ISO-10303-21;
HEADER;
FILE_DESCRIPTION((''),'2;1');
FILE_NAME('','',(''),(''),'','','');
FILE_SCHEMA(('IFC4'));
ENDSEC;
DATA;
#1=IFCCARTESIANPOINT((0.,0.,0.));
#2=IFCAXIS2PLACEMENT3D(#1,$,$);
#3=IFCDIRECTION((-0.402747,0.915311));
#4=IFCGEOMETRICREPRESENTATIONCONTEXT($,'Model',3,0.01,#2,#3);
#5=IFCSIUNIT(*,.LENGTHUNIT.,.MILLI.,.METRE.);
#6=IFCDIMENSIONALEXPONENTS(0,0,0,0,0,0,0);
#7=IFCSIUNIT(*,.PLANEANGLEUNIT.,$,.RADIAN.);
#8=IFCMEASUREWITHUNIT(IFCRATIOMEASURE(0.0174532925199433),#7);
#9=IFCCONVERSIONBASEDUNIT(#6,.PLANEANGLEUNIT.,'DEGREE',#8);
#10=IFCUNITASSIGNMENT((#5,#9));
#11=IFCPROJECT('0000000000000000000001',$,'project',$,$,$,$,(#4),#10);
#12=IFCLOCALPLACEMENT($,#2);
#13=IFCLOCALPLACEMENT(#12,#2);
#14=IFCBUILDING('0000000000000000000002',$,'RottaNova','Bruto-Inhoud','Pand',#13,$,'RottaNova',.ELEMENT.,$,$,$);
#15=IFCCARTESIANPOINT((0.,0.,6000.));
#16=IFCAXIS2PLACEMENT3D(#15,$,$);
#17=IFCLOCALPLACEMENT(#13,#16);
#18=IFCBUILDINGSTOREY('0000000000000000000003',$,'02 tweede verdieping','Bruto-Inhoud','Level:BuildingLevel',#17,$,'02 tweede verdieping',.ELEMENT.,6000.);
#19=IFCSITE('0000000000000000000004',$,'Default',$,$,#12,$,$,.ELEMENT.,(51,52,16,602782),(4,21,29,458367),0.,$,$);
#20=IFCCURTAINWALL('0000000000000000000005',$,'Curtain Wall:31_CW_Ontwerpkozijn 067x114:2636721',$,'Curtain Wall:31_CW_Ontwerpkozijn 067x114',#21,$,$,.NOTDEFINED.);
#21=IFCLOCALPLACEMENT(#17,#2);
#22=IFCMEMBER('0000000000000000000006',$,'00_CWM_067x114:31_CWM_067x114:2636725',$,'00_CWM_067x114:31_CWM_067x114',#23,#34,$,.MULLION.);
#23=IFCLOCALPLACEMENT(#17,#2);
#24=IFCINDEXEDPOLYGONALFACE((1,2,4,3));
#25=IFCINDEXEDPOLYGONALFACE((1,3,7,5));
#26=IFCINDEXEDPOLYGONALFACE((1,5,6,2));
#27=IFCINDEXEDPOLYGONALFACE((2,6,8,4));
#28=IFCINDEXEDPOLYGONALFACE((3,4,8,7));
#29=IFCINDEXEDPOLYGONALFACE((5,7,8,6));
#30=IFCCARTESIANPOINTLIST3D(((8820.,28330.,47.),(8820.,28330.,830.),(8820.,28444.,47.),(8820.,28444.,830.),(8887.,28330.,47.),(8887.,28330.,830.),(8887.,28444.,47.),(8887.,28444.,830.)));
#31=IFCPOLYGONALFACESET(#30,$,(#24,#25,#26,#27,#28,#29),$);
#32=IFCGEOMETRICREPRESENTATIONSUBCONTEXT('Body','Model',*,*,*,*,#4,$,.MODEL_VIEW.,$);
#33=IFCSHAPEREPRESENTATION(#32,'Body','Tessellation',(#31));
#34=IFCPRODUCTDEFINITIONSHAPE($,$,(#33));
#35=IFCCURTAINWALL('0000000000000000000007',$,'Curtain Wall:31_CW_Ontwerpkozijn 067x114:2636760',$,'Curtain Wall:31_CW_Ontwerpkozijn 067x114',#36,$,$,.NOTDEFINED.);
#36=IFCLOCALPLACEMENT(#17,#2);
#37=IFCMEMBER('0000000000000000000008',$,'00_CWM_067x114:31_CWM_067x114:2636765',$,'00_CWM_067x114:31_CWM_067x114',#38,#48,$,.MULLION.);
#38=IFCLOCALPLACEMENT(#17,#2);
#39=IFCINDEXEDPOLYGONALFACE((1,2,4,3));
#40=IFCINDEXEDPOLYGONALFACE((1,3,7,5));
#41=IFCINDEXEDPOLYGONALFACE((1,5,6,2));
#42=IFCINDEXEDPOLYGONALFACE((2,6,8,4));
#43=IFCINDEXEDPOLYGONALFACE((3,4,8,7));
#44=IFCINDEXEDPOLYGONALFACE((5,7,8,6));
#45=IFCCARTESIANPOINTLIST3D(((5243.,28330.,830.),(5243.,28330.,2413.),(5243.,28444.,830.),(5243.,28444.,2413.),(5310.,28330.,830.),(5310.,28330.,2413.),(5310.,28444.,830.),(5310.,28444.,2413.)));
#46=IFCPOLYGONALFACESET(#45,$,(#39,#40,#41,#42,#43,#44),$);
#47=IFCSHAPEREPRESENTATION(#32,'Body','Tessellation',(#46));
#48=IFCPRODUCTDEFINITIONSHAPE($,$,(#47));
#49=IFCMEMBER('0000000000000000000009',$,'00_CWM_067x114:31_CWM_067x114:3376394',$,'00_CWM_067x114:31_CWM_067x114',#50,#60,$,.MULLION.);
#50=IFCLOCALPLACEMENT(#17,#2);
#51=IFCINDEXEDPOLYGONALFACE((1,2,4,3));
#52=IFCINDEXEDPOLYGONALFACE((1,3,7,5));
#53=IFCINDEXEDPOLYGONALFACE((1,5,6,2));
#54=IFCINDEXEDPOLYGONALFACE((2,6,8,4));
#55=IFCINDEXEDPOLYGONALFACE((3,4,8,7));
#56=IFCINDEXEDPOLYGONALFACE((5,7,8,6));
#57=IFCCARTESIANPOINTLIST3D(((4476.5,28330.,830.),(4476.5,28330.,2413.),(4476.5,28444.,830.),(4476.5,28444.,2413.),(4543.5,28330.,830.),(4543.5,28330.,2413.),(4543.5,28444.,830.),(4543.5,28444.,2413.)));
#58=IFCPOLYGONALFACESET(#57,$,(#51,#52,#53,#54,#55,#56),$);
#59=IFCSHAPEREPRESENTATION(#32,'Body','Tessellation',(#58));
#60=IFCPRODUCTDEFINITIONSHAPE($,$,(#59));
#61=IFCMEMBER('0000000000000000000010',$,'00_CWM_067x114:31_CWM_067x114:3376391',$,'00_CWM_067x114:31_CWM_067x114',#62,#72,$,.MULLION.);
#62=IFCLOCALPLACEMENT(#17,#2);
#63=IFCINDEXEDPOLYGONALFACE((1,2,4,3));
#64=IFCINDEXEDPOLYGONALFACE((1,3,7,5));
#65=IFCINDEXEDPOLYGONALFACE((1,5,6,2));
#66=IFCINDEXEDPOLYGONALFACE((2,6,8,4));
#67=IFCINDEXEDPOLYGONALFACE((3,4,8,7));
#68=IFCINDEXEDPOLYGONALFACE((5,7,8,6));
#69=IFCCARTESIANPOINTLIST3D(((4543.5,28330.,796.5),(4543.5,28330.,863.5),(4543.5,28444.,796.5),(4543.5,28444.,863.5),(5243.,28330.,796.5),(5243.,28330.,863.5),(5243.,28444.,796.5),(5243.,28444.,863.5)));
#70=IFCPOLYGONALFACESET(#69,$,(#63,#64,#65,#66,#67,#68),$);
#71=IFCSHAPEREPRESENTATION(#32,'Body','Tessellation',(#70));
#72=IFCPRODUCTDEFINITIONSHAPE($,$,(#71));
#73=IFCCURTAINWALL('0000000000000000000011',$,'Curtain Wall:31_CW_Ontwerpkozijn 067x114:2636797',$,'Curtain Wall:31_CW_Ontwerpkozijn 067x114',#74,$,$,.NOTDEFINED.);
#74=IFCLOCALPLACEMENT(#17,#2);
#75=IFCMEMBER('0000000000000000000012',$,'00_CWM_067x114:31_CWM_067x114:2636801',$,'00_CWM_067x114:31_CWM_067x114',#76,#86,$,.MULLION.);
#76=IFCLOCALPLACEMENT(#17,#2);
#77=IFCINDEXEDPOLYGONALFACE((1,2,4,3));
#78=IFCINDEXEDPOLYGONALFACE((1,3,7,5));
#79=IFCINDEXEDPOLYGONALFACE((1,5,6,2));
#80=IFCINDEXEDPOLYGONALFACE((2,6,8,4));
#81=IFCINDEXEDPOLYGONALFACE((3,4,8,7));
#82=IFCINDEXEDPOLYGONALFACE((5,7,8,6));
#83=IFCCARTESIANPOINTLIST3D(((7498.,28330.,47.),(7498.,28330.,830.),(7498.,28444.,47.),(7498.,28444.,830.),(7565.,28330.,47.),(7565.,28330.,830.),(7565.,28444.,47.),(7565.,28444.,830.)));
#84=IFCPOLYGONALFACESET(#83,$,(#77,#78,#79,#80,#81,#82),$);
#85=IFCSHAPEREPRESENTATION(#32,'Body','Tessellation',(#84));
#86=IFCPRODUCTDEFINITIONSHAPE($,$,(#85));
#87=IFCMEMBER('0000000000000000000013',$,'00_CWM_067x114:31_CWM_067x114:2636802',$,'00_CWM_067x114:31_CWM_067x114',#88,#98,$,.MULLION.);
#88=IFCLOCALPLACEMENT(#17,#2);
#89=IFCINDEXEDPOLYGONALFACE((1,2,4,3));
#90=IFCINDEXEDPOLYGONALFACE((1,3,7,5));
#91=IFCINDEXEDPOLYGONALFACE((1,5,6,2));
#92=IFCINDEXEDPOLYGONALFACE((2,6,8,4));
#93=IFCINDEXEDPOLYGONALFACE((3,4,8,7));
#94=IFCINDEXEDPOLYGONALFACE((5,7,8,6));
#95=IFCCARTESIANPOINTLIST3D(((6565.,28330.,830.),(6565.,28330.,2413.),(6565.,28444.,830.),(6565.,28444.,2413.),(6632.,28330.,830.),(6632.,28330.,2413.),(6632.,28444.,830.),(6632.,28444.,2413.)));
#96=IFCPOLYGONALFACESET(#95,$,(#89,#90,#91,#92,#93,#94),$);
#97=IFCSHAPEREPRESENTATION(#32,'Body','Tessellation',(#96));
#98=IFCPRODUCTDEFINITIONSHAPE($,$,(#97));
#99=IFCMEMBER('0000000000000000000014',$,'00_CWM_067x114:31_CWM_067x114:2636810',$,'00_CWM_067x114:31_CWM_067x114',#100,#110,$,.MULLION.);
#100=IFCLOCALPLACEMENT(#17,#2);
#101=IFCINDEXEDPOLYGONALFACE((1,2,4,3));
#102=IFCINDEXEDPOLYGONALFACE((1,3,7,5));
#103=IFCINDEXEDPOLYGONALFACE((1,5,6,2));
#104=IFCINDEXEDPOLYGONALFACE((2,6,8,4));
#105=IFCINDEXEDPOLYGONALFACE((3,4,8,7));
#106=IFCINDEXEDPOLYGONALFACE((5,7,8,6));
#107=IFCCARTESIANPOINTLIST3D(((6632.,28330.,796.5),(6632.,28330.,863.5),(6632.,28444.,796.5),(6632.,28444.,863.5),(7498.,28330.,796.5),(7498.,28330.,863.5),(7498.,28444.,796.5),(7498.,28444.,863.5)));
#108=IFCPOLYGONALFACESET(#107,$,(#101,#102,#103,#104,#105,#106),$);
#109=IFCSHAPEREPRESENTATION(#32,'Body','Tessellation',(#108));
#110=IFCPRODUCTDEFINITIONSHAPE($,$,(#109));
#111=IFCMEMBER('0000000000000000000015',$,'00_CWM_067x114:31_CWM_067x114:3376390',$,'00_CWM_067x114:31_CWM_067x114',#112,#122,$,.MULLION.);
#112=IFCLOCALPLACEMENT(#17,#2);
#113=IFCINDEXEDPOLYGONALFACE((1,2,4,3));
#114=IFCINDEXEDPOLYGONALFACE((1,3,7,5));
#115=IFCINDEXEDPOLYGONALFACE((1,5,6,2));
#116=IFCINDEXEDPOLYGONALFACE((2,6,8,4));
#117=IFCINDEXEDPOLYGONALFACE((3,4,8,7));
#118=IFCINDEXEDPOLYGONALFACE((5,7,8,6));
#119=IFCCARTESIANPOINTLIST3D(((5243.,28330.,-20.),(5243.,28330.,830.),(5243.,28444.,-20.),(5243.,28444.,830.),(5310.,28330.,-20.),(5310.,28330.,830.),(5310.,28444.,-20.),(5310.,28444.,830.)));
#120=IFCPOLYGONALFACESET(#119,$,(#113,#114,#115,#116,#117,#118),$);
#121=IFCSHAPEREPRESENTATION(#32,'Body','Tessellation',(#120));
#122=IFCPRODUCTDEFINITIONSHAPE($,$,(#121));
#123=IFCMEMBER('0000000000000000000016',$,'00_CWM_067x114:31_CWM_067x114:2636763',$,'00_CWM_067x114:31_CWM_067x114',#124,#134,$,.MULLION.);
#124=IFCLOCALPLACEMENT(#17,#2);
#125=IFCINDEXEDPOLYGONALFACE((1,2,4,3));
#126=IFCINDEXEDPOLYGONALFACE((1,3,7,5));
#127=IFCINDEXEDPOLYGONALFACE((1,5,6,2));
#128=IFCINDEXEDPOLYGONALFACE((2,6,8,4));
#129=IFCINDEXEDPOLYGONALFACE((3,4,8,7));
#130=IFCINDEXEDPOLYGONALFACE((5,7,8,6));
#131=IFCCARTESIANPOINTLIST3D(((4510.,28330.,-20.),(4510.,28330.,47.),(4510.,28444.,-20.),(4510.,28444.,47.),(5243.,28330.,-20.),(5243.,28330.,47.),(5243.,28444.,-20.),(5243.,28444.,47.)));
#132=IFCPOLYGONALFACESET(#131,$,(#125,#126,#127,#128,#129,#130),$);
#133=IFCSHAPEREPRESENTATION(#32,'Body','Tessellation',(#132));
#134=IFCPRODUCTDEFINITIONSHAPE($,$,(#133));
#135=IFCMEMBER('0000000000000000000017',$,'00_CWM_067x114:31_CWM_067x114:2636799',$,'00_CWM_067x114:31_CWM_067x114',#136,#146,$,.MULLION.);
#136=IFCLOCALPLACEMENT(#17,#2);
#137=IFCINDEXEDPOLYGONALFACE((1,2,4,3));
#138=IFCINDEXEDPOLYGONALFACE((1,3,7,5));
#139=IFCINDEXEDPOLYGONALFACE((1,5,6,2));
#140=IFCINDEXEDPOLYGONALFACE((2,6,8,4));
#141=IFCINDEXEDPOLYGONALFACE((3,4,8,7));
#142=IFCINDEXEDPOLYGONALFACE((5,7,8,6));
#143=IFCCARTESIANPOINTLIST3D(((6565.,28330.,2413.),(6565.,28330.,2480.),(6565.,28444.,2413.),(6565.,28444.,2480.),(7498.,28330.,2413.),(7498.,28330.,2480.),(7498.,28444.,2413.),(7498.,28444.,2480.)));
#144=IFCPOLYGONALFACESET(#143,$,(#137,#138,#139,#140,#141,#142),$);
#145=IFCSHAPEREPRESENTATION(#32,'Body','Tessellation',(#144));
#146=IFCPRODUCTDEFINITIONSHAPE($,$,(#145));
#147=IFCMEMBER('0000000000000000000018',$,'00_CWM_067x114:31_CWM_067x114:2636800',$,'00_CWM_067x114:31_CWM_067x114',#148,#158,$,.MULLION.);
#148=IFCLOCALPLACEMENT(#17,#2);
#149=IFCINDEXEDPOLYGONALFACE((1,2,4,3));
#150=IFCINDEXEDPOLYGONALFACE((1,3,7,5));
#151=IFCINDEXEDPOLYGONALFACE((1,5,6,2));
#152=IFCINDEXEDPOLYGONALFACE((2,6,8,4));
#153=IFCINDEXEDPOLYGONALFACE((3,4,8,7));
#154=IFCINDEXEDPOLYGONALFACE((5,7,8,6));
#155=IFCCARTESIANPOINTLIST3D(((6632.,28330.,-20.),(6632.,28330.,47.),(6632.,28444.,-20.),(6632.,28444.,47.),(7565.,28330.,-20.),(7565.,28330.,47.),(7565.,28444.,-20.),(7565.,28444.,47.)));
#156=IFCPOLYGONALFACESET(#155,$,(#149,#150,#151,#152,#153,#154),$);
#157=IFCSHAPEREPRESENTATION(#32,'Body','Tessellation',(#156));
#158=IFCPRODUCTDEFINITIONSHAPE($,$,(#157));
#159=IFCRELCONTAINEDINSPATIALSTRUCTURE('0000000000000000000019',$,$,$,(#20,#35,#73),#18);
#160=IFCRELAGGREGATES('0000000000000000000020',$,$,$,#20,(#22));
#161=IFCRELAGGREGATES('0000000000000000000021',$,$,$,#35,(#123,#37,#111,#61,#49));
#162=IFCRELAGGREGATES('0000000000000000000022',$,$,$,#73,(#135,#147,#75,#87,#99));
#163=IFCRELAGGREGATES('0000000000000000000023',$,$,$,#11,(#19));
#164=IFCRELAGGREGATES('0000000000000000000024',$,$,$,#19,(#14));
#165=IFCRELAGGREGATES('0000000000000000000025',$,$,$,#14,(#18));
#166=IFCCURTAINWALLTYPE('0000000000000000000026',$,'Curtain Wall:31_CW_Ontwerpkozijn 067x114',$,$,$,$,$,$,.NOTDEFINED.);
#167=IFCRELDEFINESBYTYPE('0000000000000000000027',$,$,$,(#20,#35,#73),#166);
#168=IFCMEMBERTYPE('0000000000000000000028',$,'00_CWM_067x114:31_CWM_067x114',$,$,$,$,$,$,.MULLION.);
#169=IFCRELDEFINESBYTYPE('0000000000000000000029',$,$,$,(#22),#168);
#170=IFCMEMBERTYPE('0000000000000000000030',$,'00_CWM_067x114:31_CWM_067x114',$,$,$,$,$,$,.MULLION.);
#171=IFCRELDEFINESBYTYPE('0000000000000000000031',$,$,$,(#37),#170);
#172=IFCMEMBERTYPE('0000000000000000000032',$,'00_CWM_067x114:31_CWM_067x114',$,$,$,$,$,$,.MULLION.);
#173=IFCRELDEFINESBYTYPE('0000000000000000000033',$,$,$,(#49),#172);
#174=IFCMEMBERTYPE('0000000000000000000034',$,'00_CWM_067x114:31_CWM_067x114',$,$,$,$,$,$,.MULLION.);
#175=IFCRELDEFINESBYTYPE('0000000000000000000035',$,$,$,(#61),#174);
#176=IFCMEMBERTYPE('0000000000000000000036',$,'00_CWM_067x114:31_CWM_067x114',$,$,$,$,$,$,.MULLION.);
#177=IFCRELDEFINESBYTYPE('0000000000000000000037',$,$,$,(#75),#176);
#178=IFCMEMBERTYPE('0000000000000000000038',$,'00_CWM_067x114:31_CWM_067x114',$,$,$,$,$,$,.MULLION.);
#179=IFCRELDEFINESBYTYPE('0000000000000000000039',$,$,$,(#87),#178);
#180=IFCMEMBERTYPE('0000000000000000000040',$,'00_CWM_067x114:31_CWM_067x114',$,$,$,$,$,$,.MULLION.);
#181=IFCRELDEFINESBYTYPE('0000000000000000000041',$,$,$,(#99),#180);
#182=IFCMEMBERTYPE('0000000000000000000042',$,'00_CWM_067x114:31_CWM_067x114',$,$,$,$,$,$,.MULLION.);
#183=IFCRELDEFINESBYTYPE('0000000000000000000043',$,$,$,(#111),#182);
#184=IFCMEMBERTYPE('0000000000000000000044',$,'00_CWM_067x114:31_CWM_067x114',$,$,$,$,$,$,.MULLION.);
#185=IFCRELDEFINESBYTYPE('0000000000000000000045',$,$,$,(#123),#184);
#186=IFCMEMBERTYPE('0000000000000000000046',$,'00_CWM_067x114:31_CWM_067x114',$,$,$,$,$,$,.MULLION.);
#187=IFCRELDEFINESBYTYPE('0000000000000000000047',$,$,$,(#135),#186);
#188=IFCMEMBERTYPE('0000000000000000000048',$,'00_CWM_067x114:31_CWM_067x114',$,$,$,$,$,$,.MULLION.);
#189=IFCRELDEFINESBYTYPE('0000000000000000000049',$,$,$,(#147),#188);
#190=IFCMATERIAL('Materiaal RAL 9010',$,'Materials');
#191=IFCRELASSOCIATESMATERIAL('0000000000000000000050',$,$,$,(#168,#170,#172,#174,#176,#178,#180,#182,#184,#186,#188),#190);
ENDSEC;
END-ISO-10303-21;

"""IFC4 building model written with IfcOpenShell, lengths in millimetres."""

from ifc_helpers import new_model, entity, si_unit, converted_unit, direction, frame, frame_2d, origin, origin_2d_with_axis, place, context, subcontext, project, spatial, rectangle, extrude, source, transform, mapped, material, material_profile, profile_set, type_object, type_shapes, element, aggregate, save


model = new_model("IFC4")

# Units and contexts
model_context = context("Model", 3, precision=0.01, world=origin(), true_north=direction((-0.402747, 0.915311)))
body_context = subcontext(model_context, "Body", "Model", "MODEL_VIEW")
ifc_project = project(units=[si_unit("LENGTHUNIT", "METRE", prefix="MILLI"), converted_unit("PLANEANGLEUNIT", "DEGREE", entity("IfcRatioMeasure", 0.0174532925199433), si_unit("PLANEANGLEUNIT", "RADIAN"), dimensions=[0, 0, 0, 0, 0, 0, 0])], contexts=[model_context])

# Site, building, storey
site_placement = place(None, origin())
site = spatial("IfcSite", under=ifc_project, at=site_placement, Name="Default", CompositionType="ELEMENT", RefLatitude=(51, 52, 16, 602782), RefLongitude=(4, 21, 29, 458367), RefElevation=0.0)
building_placement = place(site_placement, origin())
building = spatial("IfcBuilding", under=site, at=building_placement, Name="RottaNova", Description="Bruto-Inhoud", ObjectType="Pand", LongName="RottaNova", CompositionType="ELEMENT")
storey_placement = place(building_placement, frame((0.0, 0.0, 6000.0)))
storey = spatial("IfcBuildingStorey", under=building, at=storey_placement, Name="02 tweede verdieping", Description="Bruto-Inhoud", ObjectType="Level:BuildingLevel", LongName="02 tweede verdieping", CompositionType="ELEMENT", Elevation=6000.0)

# Curtain wall, member
curtain_wall_type = type_object("IfcCurtainWallType", Name="Curtain Wall:31_CW_Ontwerpkozijn 067x114", PredefinedType="NOTDEFINED")
curtain_wall_1_placement = place(storey_placement, frame((0.0, 0.0, -6000.0)))
curtain_wall_1 = element("IfcCurtainWall", 1, at=curtain_wall_1_placement, inside=storey, type_object=curtain_wall_type, Name="Curtain Wall:31_CW_Ontwerpkozijn 067x114:2636721", ObjectType="Curtain Wall:31_CW_Ontwerpkozijn 067x114", PredefinedType="NOTDEFINED")
ifc_material_1 = material(Name="Materiaal RAL 9010", Category="Materials")
ifc_material_profile = material_profile(ifc_material_1, rectangle(XDim=114.0, YDim=67.0, at=origin_2d_with_axis()), Name="31_CWM_067x114")
ifc_profile_set = profile_set([ifc_material_profile], Name="31_CWM_067x114")
member_type_1 = type_object("IfcMemberType", Name="00_CWM_067x114:31_CWM_067x114", PredefinedType="MULLION", material=ifc_profile_set)
shared_shape_1 = source(origin(), body_context, "Body", "SweptSolid", [
    extrude(rectangle(XDim=114.0, YDim=67.0, at=origin_2d_with_axis()), frame((-33.5, 57.0, -783.0), z_axis=(0.0, 0.0, 1.0), x_axis=(0.0, -1.0, 0.0)), (0.0, 0.0, 1.0), 783.0),
])
type_shapes(member_type_1, [shared_shape_1])
member_1_placement = place(curtain_wall_1_placement, frame((8820.0, 28330.0, 6047.0), z_axis=(0.0, 0.0, -1.0), x_axis=(-1.0, 0.0, 0.0)))
member_1 = element("IfcMember", 2, at=member_1_placement, type_object=member_type_1, Name="00_CWM_067x114:31_CWM_067x114:2636725", ObjectType="00_CWM_067x114:31_CWM_067x114", PredefinedType="MULLION", context=body_context, shape_type="MappedRepresentation", body=[
    mapped(shared_shape_1, transform((0.0, 0.0, 0.0), scale=1.0)),
])
aggregate(curtain_wall_1, [member_1])

# Curtain walls, members
curtain_wall_2_placement = place(storey_placement, frame((0.0, 0.0, -6000.0)))
curtain_wall_2 = element("IfcCurtainWall", 3, at=curtain_wall_2_placement, inside=storey, type_object=curtain_wall_type, Name="Curtain Wall:31_CW_Ontwerpkozijn 067x114:2636760", ObjectType="Curtain Wall:31_CW_Ontwerpkozijn 067x114", PredefinedType="NOTDEFINED")
member_type_2 = type_object("IfcMemberType", Name="00_CWM_067x114:31_CWM_067x114", PredefinedType="MULLION", material=ifc_profile_set)
shared_shape_2 = source(origin(), body_context, "Body", "SweptSolid", [
    extrude(rectangle(XDim=114.0, YDim=67.0, at=origin_2d_with_axis()), frame((-33.5, 57.0, -1583.0), z_axis=(0.0, 0.0, 1.0), x_axis=(0.0, -1.0, 0.0)), (0.0, 0.0, 1.0), 1583.0),
])
type_shapes(member_type_2, [shared_shape_2])
member_2_placement = place(curtain_wall_2_placement, frame((5310.0, 28330.0, 8413.0)))
member_2 = element("IfcMember", 4, at=member_2_placement, type_object=member_type_2, Name="00_CWM_067x114:31_CWM_067x114:2636765", ObjectType="00_CWM_067x114:31_CWM_067x114", PredefinedType="MULLION", context=body_context, shape_type="MappedRepresentation", body=[
    mapped(shared_shape_2, transform((0.0, 0.0, 0.0), scale=1.0)),
])
member_type_3 = type_object("IfcMemberType", Name="00_CWM_067x114:31_CWM_067x114", PredefinedType="MULLION", material=ifc_profile_set)
shared_shape_3 = source(origin(), body_context, "Body", "SweptSolid", [
    extrude(rectangle(XDim=114.0, YDim=67.0, at=origin_2d_with_axis()), frame((0.0, 57.0, -1583.0), z_axis=(0.0, 0.0, 1.0), x_axis=(0.0, -1.0, 0.0)), (0.0, 0.0, 1.0), 1583.0),
])
type_shapes(member_type_3, [shared_shape_3])
member_3_placement = place(curtain_wall_2_placement, frame((4510.0, 28330.0, 6830.0), z_axis=(0.0, 0.0, -1.0), x_axis=(-1.0, 0.0, 0.0)))
member_3 = element("IfcMember", 5, at=member_3_placement, type_object=member_type_3, Name="00_CWM_067x114:31_CWM_067x114:3376394", ObjectType="00_CWM_067x114:31_CWM_067x114", PredefinedType="MULLION", context=body_context, shape_type="MappedRepresentation", body=[
    mapped(shared_shape_3, transform((0.0, 0.0, 0.0), scale=1.0)),
])
member_type_4 = type_object("IfcMemberType", Name="00_CWM_067x114:31_CWM_067x114", PredefinedType="MULLION", material=ifc_profile_set)
shared_shape_4 = source(origin(), body_context, "Body", "SweptSolid", [
    extrude(rectangle(XDim=114.0, YDim=67.0, at=origin_2d_with_axis()), frame((0.0, 57.0, -699.5), z_axis=(0.0, 0.0, 1.0), x_axis=(0.0, -1.0, 0.0)), (0.0, 0.0, 1.0), 699.5),
])
type_shapes(member_type_4, [shared_shape_4])
member_4_placement = place(curtain_wall_2_placement, frame((4543.5, 28330.0, 6830.0), z_axis=(-1.0, 0.0, 0.0), x_axis=(0.0, 0.0, 1.0)))
member_4 = element("IfcMember", 6, at=member_4_placement, type_object=member_type_4, Name="00_CWM_067x114:31_CWM_067x114:3376391", ObjectType="00_CWM_067x114:31_CWM_067x114", PredefinedType="MULLION", context=body_context, shape_type="MappedRepresentation", body=[
    mapped(shared_shape_4, transform((0.0, 0.0, 0.0), scale=1.0)),
])
curtain_wall_3_placement = place(storey_placement, frame((0.0, 0.0, -6000.0)))
curtain_wall_3 = element("IfcCurtainWall", 7, at=curtain_wall_3_placement, inside=storey, type_object=curtain_wall_type, Name="Curtain Wall:31_CW_Ontwerpkozijn 067x114:2636797", ObjectType="Curtain Wall:31_CW_Ontwerpkozijn 067x114", PredefinedType="NOTDEFINED")
member_type_5 = type_object("IfcMemberType", Name="00_CWM_067x114:31_CWM_067x114", PredefinedType="MULLION", material=ifc_profile_set)
shared_shape_5 = source(origin(), body_context, "Body", "SweptSolid", [
    extrude(rectangle(XDim=114.0, YDim=67.0, at=frame_2d((0.0, 0.0), x_axis=(1.0, 0.0))), frame((-33.5, -57.0, -783.0), z_axis=(0.0, 0.0, 1.0), x_axis=(0.0, -1.0, 0.0)), (0.0, 0.0, 1.0), 783.0),
])
type_shapes(member_type_5, [shared_shape_5])
member_5_placement = place(curtain_wall_3_placement, frame((7565.0, 28330.0, 6047.0), z_axis=(0.0, 0.0, -1.0), x_axis=(1.0, 0.0, 0.0)))
member_5 = element("IfcMember", 8, at=member_5_placement, type_object=member_type_5, Name="00_CWM_067x114:31_CWM_067x114:2636801", ObjectType="00_CWM_067x114:31_CWM_067x114", PredefinedType="MULLION", context=body_context, shape_type="MappedRepresentation", body=[
    mapped(shared_shape_5, transform((0.0, 0.0, 0.0), scale=1.0)),
])
member_type_6 = type_object("IfcMemberType", Name="00_CWM_067x114:31_CWM_067x114", PredefinedType="MULLION", material=ifc_profile_set)
shared_shape_6 = source(origin(), body_context, "Body", "SweptSolid", [
    extrude(rectangle(XDim=114.0, YDim=67.0, at=frame_2d((0.0, 0.0), x_axis=(1.0, 0.0))), frame((-33.5, -57.0, -1583.0), z_axis=(0.0, 0.0, 1.0), x_axis=(0.0, -1.0, 0.0)), (0.0, 0.0, 1.0), 1583.0),
])
type_shapes(member_type_6, [shared_shape_6])
member_6_placement = place(curtain_wall_3_placement, frame((6565.0, 28330.0, 8413.0), z_axis=(0.0, 0.0, 1.0), x_axis=(-1.0, 0.0, 0.0)))
member_6 = element("IfcMember", 9, at=member_6_placement, type_object=member_type_6, Name="00_CWM_067x114:31_CWM_067x114:2636802", ObjectType="00_CWM_067x114:31_CWM_067x114", PredefinedType="MULLION", context=body_context, shape_type="MappedRepresentation", body=[
    mapped(shared_shape_6, transform((0.0, 0.0, 0.0), scale=1.0)),
])
member_type_7 = type_object("IfcMemberType", Name="00_CWM_067x114:31_CWM_067x114", PredefinedType="MULLION", material=ifc_profile_set)
shared_shape_7 = source(origin(), body_context, "Body", "SweptSolid", [
    extrude(rectangle(XDim=114.0, YDim=67.0, at=origin_2d_with_axis()), frame((0.0, -57.0, -866.0), z_axis=(0.0, 0.0, 1.0), x_axis=(0.0, -1.0, 0.0)), (0.0, 0.0, 1.0), 866.0),
])
type_shapes(member_type_7, [shared_shape_7])
member_7_placement = place(curtain_wall_3_placement, frame((7498.0, 28330.0, 6830.0), z_axis=(1.0, 0.0, 0.0), x_axis=(0.0, 0.0, 1.0)))
member_7 = element("IfcMember", 10, at=member_7_placement, type_object=member_type_7, Name="00_CWM_067x114:31_CWM_067x114:2636810", ObjectType="00_CWM_067x114:31_CWM_067x114", PredefinedType="MULLION", context=body_context, shape_type="MappedRepresentation", body=[
    mapped(shared_shape_7, transform((0.0, 0.0, 0.0), scale=1.0)),
])

# Members
member_type_8 = type_object("IfcMemberType", Name="00_CWM_067x114:31_CWM_067x114", PredefinedType="MULLION", material=ifc_profile_set)
shared_shape_8 = source(origin(), body_context, "Body", "SweptSolid", [
    extrude(rectangle(XDim=114.0, YDim=67.0, at=origin_2d_with_axis()), frame((-33.5, 57.0, -850.0), z_axis=(0.0, 0.0, 1.0), x_axis=(0.0, -1.0, 0.0)), (0.0, 0.0, 1.0), 850.0),
])
type_shapes(member_type_8, [shared_shape_8])
member_8_placement = place(curtain_wall_2_placement, frame((5310.0, 28330.0, 6830.0)))
member_8 = element("IfcMember", 11, at=member_8_placement, type_object=member_type_8, Name="00_CWM_067x114:31_CWM_067x114:3376390", ObjectType="00_CWM_067x114:31_CWM_067x114", PredefinedType="MULLION", context=body_context, shape_type="MappedRepresentation", body=[
    mapped(shared_shape_8, transform((0.0, 0.0, 0.0), scale=1.0)),
])
member_type_9 = type_object("IfcMemberType", Name="00_CWM_067x114:31_CWM_067x114", PredefinedType="MULLION", material=ifc_profile_set)
shared_shape_9 = source(origin(), body_context, "Body", "SweptSolid", [
    extrude(rectangle(XDim=114.0, YDim=67.0, at=origin_2d_with_axis()), frame((-33.5, 57.0, -733.0), z_axis=(0.0, 0.0, 1.0), x_axis=(0.0, -1.0, 0.0)), (0.0, 0.0, 1.0), 733.0),
])
type_shapes(member_type_9, [shared_shape_9])
member_9_placement = place(curtain_wall_2_placement, frame((5243.0, 28330.0, 5980.0), z_axis=(1.0, 0.0, 0.0), x_axis=(0.0, 0.0, -1.0)))
member_9 = element("IfcMember", 12, at=member_9_placement, type_object=member_type_9, Name="00_CWM_067x114:31_CWM_067x114:2636763", ObjectType="00_CWM_067x114:31_CWM_067x114", PredefinedType="MULLION", context=body_context, shape_type="MappedRepresentation", body=[
    mapped(shared_shape_9, transform((0.0, 0.0, 0.0), scale=1.0)),
])
member_type_10 = type_object("IfcMemberType", Name="00_CWM_067x114:31_CWM_067x114", PredefinedType="MULLION", material=ifc_profile_set)
shared_shape_10 = source(origin(), body_context, "Body", "SweptSolid", [
    extrude(rectangle(XDim=114.0, YDim=67.0, at=frame_2d((0.0, 0.0), x_axis=(1.0, 0.0))), frame((-33.5, -57.0, -933.0), z_axis=(0.0, 0.0, 1.0), x_axis=(0.0, -1.0, 0.0)), (0.0, 0.0, 1.0), 933.0),
])
type_shapes(member_type_10, [shared_shape_10])
member_10_placement = place(curtain_wall_3_placement, frame((7498.0, 28330.0, 8480.0), z_axis=(1.0, 0.0, 0.0), x_axis=(0.0, 0.0, 1.0)))
member_10 = element("IfcMember", 13, at=member_10_placement, type_object=member_type_10, Name="00_CWM_067x114:31_CWM_067x114:2636799", ObjectType="00_CWM_067x114:31_CWM_067x114", PredefinedType="MULLION", context=body_context, shape_type="MappedRepresentation", body=[
    mapped(shared_shape_10, transform((0.0, 0.0, 0.0), scale=1.0)),
])
member_type_11 = type_object("IfcMemberType", Name="00_CWM_067x114:31_CWM_067x114", PredefinedType="MULLION", material=ifc_profile_set)
shared_shape_11 = source(origin(), body_context, "Body", "SweptSolid", [
    extrude(rectangle(XDim=114.0, YDim=67.0, at=origin_2d_with_axis()), frame((-33.5, -57.0, -933.0), z_axis=(0.0, 0.0, 1.0), x_axis=(0.0, -1.0, 0.0)), (0.0, 0.0, 1.0), 933.0),
])
type_shapes(member_type_11, [shared_shape_11])
member_11_placement = place(curtain_wall_3_placement, frame((6632.0, 28330.0, 5980.0), z_axis=(-1.0, 0.0, 0.0), x_axis=(0.0, 0.0, -1.0)))
member_11 = element("IfcMember", 14, at=member_11_placement, type_object=member_type_11, Name="00_CWM_067x114:31_CWM_067x114:2636800", ObjectType="00_CWM_067x114:31_CWM_067x114", PredefinedType="MULLION", context=body_context, shape_type="MappedRepresentation", body=[
    mapped(shared_shape_11, transform((0.0, 0.0, 0.0), scale=1.0)),
])

aggregate(curtain_wall_2, [member_9, member_2, member_8, member_4, member_3])

aggregate(curtain_wall_3, [member_10, member_11, member_5, member_6, member_7])

save(model, "model.ifc")
